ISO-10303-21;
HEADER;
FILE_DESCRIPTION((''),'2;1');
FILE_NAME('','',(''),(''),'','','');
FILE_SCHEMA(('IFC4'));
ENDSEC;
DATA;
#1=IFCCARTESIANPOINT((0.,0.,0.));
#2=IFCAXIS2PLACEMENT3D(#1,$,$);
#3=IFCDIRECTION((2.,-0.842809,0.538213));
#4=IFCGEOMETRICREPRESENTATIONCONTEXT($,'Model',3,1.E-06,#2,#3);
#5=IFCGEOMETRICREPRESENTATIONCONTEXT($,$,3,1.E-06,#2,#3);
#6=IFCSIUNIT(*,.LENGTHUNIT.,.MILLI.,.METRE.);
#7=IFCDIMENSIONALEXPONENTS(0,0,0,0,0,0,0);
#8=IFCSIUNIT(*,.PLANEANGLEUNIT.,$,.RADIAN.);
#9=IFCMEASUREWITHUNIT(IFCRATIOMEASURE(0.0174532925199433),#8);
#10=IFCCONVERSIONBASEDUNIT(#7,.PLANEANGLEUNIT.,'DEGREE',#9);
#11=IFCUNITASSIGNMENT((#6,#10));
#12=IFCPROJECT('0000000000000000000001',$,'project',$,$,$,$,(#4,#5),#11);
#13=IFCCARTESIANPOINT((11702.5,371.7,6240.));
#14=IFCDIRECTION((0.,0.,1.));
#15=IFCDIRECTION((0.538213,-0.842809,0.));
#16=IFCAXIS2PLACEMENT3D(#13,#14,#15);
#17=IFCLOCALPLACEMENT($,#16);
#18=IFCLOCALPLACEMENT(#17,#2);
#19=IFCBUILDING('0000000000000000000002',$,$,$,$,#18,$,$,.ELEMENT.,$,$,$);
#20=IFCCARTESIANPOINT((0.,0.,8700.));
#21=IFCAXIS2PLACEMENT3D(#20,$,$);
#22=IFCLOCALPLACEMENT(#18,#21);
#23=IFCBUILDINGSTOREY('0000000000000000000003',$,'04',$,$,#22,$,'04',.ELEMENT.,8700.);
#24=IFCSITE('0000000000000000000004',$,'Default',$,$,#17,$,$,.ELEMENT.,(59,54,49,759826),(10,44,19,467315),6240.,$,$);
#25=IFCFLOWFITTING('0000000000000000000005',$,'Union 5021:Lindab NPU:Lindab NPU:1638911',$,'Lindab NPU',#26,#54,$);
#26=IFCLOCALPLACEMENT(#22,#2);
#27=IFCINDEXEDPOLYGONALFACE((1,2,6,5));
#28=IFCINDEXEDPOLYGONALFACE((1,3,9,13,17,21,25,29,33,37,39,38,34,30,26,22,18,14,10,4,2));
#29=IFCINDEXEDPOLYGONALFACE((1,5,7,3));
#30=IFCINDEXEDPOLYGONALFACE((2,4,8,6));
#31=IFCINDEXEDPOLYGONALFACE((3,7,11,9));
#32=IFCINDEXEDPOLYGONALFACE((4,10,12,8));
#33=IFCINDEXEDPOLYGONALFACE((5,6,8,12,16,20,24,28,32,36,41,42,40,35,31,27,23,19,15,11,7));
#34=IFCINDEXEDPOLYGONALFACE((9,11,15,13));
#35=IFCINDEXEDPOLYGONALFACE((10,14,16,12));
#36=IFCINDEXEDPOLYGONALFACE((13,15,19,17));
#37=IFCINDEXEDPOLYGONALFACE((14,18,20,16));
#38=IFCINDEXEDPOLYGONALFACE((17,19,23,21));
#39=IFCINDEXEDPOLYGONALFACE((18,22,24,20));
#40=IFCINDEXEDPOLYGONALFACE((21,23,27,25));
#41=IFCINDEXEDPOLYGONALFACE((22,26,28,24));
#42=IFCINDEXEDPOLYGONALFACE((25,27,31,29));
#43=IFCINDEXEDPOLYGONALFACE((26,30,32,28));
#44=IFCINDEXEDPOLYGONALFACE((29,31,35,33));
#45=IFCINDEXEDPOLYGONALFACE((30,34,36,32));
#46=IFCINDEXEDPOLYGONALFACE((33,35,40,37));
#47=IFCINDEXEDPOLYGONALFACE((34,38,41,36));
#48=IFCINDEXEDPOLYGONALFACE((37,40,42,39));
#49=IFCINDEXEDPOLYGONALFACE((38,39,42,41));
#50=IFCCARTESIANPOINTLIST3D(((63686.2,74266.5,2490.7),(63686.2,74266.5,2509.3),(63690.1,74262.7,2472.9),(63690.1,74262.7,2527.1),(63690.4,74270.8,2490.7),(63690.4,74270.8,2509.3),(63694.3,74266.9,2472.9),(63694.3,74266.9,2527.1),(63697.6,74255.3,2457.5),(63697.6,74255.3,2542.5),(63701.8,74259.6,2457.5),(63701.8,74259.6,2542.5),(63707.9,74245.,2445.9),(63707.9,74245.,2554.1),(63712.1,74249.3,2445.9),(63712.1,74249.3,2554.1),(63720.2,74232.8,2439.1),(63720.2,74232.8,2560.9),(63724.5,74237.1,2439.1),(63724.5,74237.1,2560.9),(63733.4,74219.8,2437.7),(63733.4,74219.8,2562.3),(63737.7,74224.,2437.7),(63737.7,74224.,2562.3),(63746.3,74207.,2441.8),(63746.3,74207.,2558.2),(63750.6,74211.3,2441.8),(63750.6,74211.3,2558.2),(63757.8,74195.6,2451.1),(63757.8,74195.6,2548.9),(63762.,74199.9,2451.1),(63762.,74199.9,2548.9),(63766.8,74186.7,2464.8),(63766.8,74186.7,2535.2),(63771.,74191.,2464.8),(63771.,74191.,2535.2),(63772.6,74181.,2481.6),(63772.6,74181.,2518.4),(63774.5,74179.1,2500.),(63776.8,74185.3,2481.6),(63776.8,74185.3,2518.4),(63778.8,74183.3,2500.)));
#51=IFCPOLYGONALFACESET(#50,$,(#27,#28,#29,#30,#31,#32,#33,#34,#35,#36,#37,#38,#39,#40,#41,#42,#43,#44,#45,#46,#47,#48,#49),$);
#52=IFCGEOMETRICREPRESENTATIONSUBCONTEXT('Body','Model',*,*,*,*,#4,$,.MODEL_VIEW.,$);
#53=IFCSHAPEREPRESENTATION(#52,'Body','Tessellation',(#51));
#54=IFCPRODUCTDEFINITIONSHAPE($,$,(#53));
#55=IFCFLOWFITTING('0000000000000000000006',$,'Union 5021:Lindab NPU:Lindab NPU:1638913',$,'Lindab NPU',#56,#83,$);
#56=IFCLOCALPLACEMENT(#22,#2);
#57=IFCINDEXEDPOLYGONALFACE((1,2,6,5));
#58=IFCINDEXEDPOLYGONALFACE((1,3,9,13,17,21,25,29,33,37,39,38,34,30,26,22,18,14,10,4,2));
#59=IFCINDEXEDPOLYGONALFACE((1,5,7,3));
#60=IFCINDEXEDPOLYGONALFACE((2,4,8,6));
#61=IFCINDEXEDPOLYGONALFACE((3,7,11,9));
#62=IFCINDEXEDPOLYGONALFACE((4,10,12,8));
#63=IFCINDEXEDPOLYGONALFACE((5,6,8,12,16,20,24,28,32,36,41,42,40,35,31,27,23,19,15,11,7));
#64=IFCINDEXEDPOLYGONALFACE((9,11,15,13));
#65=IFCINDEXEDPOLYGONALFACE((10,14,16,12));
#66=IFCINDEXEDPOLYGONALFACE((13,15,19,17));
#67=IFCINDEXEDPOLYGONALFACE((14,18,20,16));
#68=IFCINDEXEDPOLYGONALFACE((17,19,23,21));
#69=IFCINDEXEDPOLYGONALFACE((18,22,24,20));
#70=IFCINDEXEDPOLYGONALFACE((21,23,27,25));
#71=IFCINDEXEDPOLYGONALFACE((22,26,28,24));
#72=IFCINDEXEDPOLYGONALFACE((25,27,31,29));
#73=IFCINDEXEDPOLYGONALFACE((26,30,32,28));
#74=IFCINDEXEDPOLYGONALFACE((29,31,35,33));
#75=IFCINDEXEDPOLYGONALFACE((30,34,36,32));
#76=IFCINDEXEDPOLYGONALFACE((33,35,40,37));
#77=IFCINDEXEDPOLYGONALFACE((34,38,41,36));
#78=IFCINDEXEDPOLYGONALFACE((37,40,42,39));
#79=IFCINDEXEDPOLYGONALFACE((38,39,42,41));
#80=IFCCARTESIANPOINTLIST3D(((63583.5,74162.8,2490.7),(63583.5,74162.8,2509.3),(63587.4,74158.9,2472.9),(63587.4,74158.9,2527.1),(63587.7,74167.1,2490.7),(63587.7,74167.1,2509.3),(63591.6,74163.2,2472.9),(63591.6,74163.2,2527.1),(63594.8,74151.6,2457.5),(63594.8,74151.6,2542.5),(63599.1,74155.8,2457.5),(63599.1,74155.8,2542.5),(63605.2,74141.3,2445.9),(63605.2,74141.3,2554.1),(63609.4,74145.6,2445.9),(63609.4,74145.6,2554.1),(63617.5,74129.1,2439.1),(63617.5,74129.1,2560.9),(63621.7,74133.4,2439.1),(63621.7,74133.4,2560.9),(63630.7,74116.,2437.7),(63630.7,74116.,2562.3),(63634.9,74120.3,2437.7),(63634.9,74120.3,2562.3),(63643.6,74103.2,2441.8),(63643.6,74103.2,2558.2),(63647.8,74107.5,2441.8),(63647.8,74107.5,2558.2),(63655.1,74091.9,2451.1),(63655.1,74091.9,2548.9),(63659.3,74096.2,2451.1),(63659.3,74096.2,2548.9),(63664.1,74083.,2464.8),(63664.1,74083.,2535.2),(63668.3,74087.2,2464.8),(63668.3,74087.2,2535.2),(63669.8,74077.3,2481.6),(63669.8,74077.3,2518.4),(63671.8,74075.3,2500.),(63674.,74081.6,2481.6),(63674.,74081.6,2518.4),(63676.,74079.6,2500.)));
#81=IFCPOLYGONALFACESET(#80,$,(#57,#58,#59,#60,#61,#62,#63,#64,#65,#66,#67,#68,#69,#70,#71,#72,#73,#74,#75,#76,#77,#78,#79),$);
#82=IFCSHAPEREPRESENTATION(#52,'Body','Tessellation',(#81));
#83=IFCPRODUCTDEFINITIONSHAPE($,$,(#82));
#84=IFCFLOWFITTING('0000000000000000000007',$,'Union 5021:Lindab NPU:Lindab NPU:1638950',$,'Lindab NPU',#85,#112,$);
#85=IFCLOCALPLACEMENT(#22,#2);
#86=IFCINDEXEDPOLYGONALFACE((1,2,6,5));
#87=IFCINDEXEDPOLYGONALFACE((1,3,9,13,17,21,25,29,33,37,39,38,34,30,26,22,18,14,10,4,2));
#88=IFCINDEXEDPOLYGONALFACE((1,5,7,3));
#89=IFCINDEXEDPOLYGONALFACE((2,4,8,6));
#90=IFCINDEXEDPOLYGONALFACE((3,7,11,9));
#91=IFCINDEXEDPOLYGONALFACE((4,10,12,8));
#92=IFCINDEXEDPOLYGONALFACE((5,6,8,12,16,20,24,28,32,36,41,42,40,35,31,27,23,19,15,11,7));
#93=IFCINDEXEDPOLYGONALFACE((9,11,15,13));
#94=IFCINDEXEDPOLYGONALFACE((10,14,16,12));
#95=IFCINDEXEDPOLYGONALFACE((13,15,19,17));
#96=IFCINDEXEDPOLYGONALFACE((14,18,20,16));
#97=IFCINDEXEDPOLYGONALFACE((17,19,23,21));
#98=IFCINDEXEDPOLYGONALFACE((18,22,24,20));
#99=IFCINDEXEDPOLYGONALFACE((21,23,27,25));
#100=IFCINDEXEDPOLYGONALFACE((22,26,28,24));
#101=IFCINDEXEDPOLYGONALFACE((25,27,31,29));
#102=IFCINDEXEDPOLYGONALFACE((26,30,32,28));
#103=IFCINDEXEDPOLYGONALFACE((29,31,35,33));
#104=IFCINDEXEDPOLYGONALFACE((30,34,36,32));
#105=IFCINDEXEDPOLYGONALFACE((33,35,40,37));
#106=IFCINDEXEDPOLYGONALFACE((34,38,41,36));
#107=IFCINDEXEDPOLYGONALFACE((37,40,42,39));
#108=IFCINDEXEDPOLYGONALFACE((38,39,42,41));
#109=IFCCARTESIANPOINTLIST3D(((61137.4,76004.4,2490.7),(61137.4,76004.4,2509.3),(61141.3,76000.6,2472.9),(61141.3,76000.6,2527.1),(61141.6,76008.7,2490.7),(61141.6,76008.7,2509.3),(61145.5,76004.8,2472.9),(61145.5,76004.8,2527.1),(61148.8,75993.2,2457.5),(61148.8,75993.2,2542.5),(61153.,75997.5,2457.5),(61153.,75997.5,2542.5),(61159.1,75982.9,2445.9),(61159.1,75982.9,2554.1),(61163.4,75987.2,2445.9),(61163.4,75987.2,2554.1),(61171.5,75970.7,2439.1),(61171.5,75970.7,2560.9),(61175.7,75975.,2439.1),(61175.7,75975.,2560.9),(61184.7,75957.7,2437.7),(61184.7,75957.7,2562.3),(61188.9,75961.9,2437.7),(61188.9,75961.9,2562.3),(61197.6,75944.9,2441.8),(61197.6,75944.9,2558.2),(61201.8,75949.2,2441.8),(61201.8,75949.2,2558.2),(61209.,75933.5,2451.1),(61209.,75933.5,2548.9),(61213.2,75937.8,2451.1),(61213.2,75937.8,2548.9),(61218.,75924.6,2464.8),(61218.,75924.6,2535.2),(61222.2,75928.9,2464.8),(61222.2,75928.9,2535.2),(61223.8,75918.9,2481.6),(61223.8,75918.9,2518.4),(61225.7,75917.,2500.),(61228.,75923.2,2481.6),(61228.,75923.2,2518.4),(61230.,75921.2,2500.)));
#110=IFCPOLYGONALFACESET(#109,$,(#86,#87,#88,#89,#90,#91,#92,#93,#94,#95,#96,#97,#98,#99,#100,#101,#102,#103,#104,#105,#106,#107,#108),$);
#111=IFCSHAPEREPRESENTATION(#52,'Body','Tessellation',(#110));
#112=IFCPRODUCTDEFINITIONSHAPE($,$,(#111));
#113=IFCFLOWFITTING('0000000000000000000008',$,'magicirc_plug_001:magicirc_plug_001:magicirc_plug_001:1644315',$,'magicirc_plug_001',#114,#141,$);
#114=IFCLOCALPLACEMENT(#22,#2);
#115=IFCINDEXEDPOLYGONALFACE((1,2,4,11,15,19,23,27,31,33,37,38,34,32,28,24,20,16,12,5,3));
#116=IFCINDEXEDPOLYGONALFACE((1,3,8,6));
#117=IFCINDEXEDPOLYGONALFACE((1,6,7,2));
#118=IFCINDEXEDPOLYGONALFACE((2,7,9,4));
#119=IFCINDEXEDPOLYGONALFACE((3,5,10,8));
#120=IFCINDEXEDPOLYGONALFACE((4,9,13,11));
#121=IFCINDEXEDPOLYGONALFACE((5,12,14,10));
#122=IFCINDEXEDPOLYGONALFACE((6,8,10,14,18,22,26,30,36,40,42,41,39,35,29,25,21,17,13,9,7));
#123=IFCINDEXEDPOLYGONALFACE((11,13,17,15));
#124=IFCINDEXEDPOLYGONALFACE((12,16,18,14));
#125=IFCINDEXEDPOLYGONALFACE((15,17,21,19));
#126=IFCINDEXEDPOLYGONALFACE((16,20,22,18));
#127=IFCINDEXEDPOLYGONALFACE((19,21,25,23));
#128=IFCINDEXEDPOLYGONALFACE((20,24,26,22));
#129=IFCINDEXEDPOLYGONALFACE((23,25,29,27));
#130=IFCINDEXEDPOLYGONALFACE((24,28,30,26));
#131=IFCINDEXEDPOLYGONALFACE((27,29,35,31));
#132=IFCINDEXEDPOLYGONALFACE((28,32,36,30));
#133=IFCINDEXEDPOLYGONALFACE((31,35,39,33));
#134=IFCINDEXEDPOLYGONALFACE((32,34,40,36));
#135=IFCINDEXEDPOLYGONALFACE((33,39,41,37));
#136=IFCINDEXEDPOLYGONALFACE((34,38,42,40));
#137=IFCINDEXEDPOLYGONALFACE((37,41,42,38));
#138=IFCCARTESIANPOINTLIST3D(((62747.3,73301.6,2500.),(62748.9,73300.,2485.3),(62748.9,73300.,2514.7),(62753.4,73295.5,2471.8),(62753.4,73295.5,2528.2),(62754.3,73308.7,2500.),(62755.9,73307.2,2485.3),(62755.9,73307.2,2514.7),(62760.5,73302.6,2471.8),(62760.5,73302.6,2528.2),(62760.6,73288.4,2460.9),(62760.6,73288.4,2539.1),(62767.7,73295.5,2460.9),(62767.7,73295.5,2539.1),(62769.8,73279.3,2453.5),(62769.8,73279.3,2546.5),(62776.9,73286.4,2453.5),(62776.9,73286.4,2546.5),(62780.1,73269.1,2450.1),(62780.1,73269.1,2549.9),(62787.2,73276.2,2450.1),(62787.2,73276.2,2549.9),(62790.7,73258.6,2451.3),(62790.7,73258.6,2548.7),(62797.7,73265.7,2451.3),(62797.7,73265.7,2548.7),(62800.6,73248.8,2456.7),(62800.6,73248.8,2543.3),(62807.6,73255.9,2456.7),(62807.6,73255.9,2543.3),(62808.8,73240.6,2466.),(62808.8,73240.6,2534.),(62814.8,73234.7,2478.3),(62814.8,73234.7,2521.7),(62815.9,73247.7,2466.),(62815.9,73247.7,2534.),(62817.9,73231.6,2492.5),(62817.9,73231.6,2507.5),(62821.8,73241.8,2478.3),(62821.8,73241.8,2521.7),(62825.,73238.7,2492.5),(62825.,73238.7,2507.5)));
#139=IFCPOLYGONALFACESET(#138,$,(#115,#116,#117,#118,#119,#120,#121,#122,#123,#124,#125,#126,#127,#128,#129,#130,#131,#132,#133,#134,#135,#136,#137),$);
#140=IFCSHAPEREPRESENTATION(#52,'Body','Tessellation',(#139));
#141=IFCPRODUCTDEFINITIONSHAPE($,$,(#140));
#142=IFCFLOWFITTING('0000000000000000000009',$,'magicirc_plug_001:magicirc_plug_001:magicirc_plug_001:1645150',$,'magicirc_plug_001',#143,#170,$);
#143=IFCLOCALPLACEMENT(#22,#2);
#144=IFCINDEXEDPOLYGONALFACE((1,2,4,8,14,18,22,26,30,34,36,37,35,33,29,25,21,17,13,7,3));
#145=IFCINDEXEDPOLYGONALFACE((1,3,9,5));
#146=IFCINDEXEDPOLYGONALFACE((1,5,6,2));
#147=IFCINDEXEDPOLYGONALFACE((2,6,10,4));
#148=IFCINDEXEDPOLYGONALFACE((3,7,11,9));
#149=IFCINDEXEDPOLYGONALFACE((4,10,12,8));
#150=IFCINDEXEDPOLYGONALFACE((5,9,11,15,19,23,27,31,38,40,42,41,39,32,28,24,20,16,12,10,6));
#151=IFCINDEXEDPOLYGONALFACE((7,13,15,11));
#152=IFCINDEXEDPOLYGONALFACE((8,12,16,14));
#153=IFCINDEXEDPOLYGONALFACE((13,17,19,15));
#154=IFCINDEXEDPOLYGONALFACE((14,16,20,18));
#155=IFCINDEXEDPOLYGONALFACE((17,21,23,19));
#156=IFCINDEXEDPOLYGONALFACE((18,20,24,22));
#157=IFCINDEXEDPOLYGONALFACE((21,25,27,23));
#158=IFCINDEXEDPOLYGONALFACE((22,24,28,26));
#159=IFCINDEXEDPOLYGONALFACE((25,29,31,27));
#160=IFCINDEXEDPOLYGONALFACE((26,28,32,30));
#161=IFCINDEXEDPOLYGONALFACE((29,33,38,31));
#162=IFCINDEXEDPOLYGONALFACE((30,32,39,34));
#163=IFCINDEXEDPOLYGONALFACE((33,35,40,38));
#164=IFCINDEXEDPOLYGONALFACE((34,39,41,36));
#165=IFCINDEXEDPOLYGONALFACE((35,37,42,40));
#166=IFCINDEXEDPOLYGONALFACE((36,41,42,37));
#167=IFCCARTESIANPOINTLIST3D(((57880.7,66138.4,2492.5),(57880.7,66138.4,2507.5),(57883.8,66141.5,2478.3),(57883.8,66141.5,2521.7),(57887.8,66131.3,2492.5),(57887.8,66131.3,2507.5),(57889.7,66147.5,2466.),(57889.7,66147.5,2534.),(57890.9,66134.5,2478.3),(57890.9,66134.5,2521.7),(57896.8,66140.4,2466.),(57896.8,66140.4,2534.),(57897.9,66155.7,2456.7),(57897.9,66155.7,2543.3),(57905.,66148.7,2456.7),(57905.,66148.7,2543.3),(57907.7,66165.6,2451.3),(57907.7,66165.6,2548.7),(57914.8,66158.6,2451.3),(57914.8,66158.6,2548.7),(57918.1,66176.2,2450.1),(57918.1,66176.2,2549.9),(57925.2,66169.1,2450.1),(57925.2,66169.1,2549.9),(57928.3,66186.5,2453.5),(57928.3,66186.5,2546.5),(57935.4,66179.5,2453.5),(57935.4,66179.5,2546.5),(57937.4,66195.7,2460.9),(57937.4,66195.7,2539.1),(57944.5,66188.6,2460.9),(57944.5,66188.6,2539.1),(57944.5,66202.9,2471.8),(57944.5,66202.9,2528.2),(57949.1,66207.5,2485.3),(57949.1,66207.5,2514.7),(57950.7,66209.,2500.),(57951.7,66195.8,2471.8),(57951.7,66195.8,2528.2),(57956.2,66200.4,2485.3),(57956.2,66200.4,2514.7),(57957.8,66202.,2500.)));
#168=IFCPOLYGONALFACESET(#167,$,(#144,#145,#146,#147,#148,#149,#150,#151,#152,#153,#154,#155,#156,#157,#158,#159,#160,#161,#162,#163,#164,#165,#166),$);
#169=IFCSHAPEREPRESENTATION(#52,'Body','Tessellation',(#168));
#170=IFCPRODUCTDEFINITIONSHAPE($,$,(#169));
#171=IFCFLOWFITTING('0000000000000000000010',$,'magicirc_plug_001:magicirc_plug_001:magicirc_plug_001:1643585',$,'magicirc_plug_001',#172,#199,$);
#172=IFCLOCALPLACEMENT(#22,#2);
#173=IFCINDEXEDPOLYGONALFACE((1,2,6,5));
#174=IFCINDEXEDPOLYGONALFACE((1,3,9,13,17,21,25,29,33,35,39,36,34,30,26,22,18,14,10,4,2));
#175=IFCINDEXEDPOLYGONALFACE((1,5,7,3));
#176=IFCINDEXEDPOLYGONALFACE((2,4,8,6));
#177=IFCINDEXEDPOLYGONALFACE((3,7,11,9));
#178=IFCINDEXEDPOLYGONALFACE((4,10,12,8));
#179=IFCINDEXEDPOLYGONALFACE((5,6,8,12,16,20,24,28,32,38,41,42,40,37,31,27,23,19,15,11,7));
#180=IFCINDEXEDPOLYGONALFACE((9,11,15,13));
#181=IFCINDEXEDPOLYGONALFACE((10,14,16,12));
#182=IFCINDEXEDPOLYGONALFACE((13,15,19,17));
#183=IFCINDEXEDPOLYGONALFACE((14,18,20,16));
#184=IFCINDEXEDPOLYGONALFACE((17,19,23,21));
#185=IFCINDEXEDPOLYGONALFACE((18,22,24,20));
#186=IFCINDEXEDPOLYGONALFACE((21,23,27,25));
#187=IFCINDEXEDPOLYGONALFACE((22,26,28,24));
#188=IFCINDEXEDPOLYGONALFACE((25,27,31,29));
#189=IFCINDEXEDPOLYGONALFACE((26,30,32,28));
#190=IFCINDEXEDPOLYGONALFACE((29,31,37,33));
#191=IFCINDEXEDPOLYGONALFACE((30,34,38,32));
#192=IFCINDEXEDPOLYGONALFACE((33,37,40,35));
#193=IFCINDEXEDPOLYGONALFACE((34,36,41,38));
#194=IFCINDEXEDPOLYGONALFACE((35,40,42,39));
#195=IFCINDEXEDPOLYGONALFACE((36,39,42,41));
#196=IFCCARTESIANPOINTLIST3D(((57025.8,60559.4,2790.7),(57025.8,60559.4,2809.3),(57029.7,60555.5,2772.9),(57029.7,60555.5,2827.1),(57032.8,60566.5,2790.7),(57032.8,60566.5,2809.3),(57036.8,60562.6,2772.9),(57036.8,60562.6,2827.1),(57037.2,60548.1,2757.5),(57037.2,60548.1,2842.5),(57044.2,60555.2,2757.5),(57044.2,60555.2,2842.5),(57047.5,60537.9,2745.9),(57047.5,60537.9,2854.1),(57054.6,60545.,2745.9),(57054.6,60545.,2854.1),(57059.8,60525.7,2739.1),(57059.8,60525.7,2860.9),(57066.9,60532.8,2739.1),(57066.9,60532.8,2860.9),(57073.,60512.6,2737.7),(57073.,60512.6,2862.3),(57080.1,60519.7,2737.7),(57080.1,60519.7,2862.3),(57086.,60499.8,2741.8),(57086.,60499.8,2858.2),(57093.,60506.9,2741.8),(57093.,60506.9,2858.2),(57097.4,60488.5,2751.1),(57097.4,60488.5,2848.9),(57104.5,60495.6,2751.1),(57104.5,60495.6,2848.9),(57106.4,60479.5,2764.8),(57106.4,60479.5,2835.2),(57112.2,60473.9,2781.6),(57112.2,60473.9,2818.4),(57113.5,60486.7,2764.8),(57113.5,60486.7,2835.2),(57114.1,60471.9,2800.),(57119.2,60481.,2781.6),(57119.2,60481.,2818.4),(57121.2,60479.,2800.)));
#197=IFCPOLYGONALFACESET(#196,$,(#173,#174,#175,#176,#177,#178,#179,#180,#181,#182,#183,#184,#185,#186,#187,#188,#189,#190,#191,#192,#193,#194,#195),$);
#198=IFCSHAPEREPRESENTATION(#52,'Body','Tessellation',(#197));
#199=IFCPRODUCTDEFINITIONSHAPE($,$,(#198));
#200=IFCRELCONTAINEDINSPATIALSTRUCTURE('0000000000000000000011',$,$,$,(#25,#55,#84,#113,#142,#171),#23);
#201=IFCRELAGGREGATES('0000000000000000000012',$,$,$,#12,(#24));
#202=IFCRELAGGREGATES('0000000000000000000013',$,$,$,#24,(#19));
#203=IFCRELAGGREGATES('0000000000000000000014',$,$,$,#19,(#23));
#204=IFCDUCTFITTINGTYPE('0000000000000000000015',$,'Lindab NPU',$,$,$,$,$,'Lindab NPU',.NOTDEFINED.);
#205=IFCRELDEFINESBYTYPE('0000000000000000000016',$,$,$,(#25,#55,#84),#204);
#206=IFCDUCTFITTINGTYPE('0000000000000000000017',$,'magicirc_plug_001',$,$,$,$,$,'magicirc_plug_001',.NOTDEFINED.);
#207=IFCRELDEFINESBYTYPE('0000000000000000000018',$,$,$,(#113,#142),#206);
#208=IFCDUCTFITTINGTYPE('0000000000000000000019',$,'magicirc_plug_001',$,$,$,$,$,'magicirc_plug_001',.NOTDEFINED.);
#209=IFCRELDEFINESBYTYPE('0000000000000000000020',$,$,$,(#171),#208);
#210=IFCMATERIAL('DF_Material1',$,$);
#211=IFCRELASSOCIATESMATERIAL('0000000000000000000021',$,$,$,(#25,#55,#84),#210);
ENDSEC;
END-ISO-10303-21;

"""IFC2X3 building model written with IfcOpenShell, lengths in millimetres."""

from ifc_helpers import new_model, entity, si_unit, converted_unit, direction, frame, frame_2d, origin, place, context, subcontext, project, spatial, circle, extrude, source, transform, mapped, material, type_object, type_shapes, element, save


model = new_model("IFC2X3")

# Units and contexts
model_context = context("Model", 3, precision=1e-06, world=origin(), true_north=direction((2.0, -0.842809, 0.538213)))
context_of_model = context(None, 3, precision=1e-06, world=origin(), true_north=direction((2.0, -0.842809, 0.538213)))
body_context = subcontext(model_context, "Body", "Model", "MODEL_VIEW")
ifc_project = project(units=[si_unit("LENGTHUNIT", "METRE", prefix="MILLI"), converted_unit("PLANEANGLEUNIT", "DEGREE", entity("IfcRatioMeasure", 0.0174532925199433), si_unit("PLANEANGLEUNIT", "RADIAN"), dimensions=[0, 0, 0, 0, 0, 0, 0])], contexts=[model_context, context_of_model])

# Site, building, storey
site_placement = place(None, frame((11702.5, 371.7, 6240.0), z_axis=(0.0, 0.0, 1.0), x_axis=(0.538213, -0.842809, 0.0)))
site = spatial("IfcSite", under=ifc_project, at=site_placement, Name="Default", CompositionType="ELEMENT", RefLatitude=(59, 54, 49, 759826), RefLongitude=(10, 44, 19, 467315), RefElevation=6240.0)
building_placement = place(site_placement, origin())
building = spatial("IfcBuilding", under=site, at=building_placement, CompositionType="ELEMENT")
storey_placement = place(building_placement, frame((0.0, 0.0, 8700.0)))
storey = spatial("IfcBuildingStorey", under=building, at=storey_placement, Name="04", LongName="04", CompositionType="ELEMENT", Elevation=8700.0)

# Flow fittings
ifc_material = material(Name="DF_Material1")
duct_fitting_type_1 = type_object("IfcDuctFittingType", Name="Lindab NPU", ElementType="Lindab NPU", PredefinedType="NOTDEFINED")
shared_shape_1 = source(origin(), body_context, "Body", "SweptSolid", [
    extrude(circle(Radius=62.5, at=frame_2d((0.0, 0.0), x_axis=(1.0, 0.0))), frame((0.0, 0.0, 0.0), z_axis=(1.0, 0.0, 0.0), x_axis=(0.0, 1.0, 0.0)), (0.0, 0.0, 1.0), 6.0),
])
type_shapes(duct_fitting_type_1, [shared_shape_1])
for number, where, z_axis, x_axis, name in (
    (1, (63734.3, 74227.3, 2500.0), (0.0, 0.0, 1.0), (-0.703643, -0.710554, 0.0), "Union 5021:Lindab NPU:Lindab NPU:1638911"),
    (2, (63631.6, 74123.6, 2500.0), (0.0, 0.0, 1.0), (-0.703643, -0.710554, 0.0), "Union 5021:Lindab NPU:Lindab NPU:1638913"),
    (3, (61185.6, 75965.2, 2500.0), (0.0, 0.0, 1.0), (-0.703643, -0.710554, 0.0), "Union 5021:Lindab NPU:Lindab NPU:1638950"),
):
    element("IfcFlowFitting", number, at=place(storey_placement, frame(where, z_axis=z_axis, x_axis=x_axis)), inside=storey, type_object=duct_fitting_type_1, material=ifc_material, Name=name, ObjectType="Lindab NPU", context=body_context, shape_type="MappedRepresentation", body=[
        mapped(shared_shape_1, transform((0.0, 0.0, 0.0), scale=1.0)),
    ])

# Flow fittings
duct_fitting_type_2 = type_object("IfcDuctFittingType", Name="magicirc_plug_001", ElementType="magicirc_plug_001", PredefinedType="NOTDEFINED")
shared_shape_2 = source(origin(), body_context, "Body", "SweptSolid", [
    extrude(circle(Radius=50.0, at=frame_2d((0.0, 0.0), x_axis=(1.0, 0.0))), frame((0.0, 0.0, 0.0), z_axis=(1.0, 0.0, 0.0), x_axis=(0.0, 1.0, 0.0)), (0.0, 0.0, 1.0), 10.0),
])
type_shapes(duct_fitting_type_2, [shared_shape_2])
for number, where, z_axis, x_axis, name in (
    (4, (62782.8, 73266.4, 2500.0), (0.0, 0.0, 1.0), (0.703643, 0.710554, 0.0), "magicirc_plug_001:magicirc_plug_001:magicirc_plug_001:1644315"),
    (5, (57915.5, 66173.5, 2500.0), (0.0, 0.0, 1.0), (0.710554, -0.703643, 0.0), "magicirc_plug_001:magicirc_plug_001:magicirc_plug_001:1645150"),
):
    element("IfcFlowFitting", number, at=place(storey_placement, frame(where, z_axis=z_axis, x_axis=x_axis)), inside=storey, type_object=duct_fitting_type_2, Name=name, ObjectType="magicirc_plug_001", context=body_context, shape_type="MappedRepresentation", body=[
        mapped(shared_shape_2, transform((0.0, 0.0, 0.0), scale=1.0)),
    ])
duct_fitting_type_3 = type_object("IfcDuctFittingType", Name="magicirc_plug_001", ElementType="magicirc_plug_001", PredefinedType="NOTDEFINED")
shared_shape_3 = source(origin(), body_context, "Body", "SweptSolid", [
    extrude(circle(Radius=62.5, at=frame_2d((0.0, 0.0), x_axis=(1.0, 0.0))), frame((0.0, 0.0, 0.0), z_axis=(1.0, 0.0, 0.0), x_axis=(0.0, 1.0, 0.0)), (0.0, 0.0, 1.0), 10.0),
])
type_shapes(duct_fitting_type_3, [shared_shape_3])
for number, where, z_axis, x_axis, name in (
    (6, (57076.8, 60523.0, 2800.0), (0.0, 0.0, 1.0), (-0.703643, -0.710554, 0.0), "magicirc_plug_001:magicirc_plug_001:magicirc_plug_001:1643585"),
):
    element("IfcFlowFitting", number, at=place(storey_placement, frame(where, z_axis=z_axis, x_axis=x_axis)), inside=storey, type_object=duct_fitting_type_3, Name=name, ObjectType="magicirc_plug_001", context=body_context, shape_type="MappedRepresentation", body=[
        mapped(shared_shape_3, transform((0.0, 0.0, 0.0), scale=1.0)),
    ])

save(model, "model.ifc")
